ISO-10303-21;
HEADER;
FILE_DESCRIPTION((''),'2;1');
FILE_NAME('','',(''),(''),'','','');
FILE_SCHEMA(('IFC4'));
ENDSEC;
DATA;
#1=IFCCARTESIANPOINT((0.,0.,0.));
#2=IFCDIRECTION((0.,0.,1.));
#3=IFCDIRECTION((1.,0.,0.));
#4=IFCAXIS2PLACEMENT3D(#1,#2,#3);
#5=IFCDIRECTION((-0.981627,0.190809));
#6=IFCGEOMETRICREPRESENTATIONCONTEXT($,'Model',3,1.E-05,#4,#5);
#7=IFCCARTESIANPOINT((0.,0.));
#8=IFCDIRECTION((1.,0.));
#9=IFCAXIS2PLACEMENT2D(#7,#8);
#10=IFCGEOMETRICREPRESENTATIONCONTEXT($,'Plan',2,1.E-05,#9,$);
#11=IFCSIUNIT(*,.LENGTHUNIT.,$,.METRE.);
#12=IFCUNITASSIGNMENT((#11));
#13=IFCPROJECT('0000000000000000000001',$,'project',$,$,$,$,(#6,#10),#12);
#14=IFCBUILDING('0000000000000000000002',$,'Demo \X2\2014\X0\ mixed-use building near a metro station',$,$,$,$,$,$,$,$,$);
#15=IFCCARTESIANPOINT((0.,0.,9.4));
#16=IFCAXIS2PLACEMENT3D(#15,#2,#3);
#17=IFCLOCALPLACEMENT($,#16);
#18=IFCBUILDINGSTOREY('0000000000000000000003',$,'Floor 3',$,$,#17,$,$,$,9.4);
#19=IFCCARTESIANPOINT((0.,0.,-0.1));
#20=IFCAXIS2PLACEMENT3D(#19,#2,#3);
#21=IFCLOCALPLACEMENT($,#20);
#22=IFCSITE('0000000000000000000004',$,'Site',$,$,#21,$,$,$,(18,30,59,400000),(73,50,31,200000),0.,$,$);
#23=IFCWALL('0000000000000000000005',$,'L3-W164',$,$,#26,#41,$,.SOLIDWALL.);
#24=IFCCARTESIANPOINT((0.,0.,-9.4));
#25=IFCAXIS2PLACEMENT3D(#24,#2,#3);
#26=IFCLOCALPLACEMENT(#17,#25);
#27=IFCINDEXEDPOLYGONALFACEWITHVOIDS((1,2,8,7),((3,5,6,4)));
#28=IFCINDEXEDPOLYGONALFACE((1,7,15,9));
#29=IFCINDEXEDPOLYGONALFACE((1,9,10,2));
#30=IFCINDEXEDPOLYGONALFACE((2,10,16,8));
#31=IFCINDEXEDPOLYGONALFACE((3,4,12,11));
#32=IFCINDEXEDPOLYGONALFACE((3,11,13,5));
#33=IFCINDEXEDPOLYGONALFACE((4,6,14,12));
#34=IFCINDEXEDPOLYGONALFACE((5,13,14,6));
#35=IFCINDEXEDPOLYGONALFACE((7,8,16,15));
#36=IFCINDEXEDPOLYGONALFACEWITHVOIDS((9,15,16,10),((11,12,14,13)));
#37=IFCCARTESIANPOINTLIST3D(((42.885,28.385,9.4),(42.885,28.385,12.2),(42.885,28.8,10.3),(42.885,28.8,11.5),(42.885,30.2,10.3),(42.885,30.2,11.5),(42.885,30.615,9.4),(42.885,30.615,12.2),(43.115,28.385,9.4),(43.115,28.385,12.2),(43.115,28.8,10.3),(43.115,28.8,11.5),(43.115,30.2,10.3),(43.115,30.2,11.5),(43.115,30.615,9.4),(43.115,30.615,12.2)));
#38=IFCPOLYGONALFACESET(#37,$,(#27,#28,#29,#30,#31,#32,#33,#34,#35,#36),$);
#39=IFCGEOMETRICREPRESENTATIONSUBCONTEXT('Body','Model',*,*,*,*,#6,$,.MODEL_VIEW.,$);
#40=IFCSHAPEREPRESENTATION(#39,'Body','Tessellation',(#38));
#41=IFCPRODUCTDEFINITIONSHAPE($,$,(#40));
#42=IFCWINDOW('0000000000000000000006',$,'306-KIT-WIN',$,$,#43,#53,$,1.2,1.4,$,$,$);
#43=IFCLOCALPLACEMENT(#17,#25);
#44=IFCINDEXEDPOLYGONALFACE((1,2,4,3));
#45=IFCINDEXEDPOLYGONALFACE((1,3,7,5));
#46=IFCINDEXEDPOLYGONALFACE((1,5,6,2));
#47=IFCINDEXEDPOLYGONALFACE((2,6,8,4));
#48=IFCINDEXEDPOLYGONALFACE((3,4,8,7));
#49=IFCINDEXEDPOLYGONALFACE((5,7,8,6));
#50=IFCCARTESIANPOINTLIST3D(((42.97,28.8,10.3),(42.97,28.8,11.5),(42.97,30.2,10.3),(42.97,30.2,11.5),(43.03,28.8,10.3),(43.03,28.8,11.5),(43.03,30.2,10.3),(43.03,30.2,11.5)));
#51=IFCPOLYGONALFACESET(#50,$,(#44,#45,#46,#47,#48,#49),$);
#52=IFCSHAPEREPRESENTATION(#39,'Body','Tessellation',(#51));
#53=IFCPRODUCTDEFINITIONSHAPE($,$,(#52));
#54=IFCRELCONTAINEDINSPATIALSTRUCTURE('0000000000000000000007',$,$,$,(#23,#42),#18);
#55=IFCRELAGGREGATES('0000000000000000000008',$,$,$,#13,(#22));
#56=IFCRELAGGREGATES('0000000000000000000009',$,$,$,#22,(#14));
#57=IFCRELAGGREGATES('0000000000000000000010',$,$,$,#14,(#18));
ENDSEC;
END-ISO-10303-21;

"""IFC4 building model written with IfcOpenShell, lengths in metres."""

from ifc_helpers import new_model, si_unit, direction, frame, origin_with_axes, origin_2d_with_axis, place, context, subcontext, project, spatial, line, indexed_curve, outline, extrude, element, fill, save


model = new_model("IFC4")

# Units and contexts
model_context = context("Model", 3, precision=1e-05, world=origin_with_axes(), true_north=direction((-0.981627, 0.190809)))
plan_context = context("Plan", 2, precision=1e-05, world=origin_2d_with_axis())
body_context = subcontext(model_context, "Body", "Model", "MODEL_VIEW")
ifc_project = project(units=[si_unit("LENGTHUNIT", "METRE")], contexts=[model_context, plan_context])

# Site, building, storey
site_placement = place(None, frame((0.0, 0.0, -0.1), z_axis=(0.0, 0.0, 1.0), x_axis=(1.0, 0.0, 0.0)))
site = spatial("IfcSite", under=ifc_project, at=site_placement, Name="Site", RefLatitude=(18, 30, 59, 400000), RefLongitude=(73, 50, 31, 200000), RefElevation=0.0)
building = spatial("IfcBuilding", under=site, Name="Demo — mixed-use building near a metro station")
storey_placement = place(None, frame((0.0, 0.0, 9.4), z_axis=(0.0, 0.0, 1.0), x_axis=(1.0, 0.0, 0.0)))
storey = spatial("IfcBuildingStorey", under=building, at=storey_placement, Name="Floor 3", Elevation=9.4)

# Wall, opening, window
wall_1_placement = place(storey_placement, frame((0.0, 0.0, -9.4), z_axis=(0.0, 0.0, 1.0), x_axis=(1.0, 0.0, 0.0)))
wall_1 = element("IfcWall", 1, at=wall_1_placement, inside=storey, Name="L3-W164", PredefinedType="SOLIDWALL", context=body_context, shape_type="SweptSolid", body=[
    extrude(outline(indexed_curve([(42.885, 28.385), (42.885, 30.615), (43.115, 30.615), (43.115, 28.385)], segments=[line(1, 2, 3, 4, 1)])), frame((0.0, 0.0, 9.4), z_axis=(0.0, 0.0, 1.0), x_axis=(1.0, 0.0, 0.0)), (0.0, 0.0, 1.0), 2.8),
])
opening_1_placement = place(wall_1_placement, origin_with_axes())
opening_1 = element("IfcOpeningElement", 2, at=opening_1_placement, cuts=wall_1, context=body_context, shape_type="SweptSolid", body=[
    extrude(outline(indexed_curve([(42.835, 28.8), (42.835, 30.2), (43.165, 30.2), (43.165, 28.8)], segments=[line(1, 2, 3, 4, 1)])), frame((0.0, 0.0, 10.3), z_axis=(0.0, 0.0, 1.0), x_axis=(1.0, 0.0, 0.0)), (0.0, 0.0, 1.0), 1.2),
])
window_1_placement = place(storey_placement, frame((0.0, 0.0, -9.4), z_axis=(0.0, 0.0, 1.0), x_axis=(1.0, 0.0, 0.0)))
window_1 = element("IfcWindow", 3, at=window_1_placement, inside=storey, Name="306-KIT-WIN", OverallHeight=1.2, OverallWidth=1.4, context=body_context, shape_type="SweptSolid", body=[
    extrude(outline(indexed_curve([(42.97, 28.8), (42.97, 30.2), (43.03, 30.2), (43.03, 28.8)], segments=[line(1, 2, 3, 4, 1)])), frame((0.0, 0.0, 10.3), z_axis=(0.0, 0.0, 1.0), x_axis=(1.0, 0.0, 0.0)), (0.0, 0.0, 1.0), 1.2),
])
fill(opening_1, window_1)

save(model, "model.ifc")
